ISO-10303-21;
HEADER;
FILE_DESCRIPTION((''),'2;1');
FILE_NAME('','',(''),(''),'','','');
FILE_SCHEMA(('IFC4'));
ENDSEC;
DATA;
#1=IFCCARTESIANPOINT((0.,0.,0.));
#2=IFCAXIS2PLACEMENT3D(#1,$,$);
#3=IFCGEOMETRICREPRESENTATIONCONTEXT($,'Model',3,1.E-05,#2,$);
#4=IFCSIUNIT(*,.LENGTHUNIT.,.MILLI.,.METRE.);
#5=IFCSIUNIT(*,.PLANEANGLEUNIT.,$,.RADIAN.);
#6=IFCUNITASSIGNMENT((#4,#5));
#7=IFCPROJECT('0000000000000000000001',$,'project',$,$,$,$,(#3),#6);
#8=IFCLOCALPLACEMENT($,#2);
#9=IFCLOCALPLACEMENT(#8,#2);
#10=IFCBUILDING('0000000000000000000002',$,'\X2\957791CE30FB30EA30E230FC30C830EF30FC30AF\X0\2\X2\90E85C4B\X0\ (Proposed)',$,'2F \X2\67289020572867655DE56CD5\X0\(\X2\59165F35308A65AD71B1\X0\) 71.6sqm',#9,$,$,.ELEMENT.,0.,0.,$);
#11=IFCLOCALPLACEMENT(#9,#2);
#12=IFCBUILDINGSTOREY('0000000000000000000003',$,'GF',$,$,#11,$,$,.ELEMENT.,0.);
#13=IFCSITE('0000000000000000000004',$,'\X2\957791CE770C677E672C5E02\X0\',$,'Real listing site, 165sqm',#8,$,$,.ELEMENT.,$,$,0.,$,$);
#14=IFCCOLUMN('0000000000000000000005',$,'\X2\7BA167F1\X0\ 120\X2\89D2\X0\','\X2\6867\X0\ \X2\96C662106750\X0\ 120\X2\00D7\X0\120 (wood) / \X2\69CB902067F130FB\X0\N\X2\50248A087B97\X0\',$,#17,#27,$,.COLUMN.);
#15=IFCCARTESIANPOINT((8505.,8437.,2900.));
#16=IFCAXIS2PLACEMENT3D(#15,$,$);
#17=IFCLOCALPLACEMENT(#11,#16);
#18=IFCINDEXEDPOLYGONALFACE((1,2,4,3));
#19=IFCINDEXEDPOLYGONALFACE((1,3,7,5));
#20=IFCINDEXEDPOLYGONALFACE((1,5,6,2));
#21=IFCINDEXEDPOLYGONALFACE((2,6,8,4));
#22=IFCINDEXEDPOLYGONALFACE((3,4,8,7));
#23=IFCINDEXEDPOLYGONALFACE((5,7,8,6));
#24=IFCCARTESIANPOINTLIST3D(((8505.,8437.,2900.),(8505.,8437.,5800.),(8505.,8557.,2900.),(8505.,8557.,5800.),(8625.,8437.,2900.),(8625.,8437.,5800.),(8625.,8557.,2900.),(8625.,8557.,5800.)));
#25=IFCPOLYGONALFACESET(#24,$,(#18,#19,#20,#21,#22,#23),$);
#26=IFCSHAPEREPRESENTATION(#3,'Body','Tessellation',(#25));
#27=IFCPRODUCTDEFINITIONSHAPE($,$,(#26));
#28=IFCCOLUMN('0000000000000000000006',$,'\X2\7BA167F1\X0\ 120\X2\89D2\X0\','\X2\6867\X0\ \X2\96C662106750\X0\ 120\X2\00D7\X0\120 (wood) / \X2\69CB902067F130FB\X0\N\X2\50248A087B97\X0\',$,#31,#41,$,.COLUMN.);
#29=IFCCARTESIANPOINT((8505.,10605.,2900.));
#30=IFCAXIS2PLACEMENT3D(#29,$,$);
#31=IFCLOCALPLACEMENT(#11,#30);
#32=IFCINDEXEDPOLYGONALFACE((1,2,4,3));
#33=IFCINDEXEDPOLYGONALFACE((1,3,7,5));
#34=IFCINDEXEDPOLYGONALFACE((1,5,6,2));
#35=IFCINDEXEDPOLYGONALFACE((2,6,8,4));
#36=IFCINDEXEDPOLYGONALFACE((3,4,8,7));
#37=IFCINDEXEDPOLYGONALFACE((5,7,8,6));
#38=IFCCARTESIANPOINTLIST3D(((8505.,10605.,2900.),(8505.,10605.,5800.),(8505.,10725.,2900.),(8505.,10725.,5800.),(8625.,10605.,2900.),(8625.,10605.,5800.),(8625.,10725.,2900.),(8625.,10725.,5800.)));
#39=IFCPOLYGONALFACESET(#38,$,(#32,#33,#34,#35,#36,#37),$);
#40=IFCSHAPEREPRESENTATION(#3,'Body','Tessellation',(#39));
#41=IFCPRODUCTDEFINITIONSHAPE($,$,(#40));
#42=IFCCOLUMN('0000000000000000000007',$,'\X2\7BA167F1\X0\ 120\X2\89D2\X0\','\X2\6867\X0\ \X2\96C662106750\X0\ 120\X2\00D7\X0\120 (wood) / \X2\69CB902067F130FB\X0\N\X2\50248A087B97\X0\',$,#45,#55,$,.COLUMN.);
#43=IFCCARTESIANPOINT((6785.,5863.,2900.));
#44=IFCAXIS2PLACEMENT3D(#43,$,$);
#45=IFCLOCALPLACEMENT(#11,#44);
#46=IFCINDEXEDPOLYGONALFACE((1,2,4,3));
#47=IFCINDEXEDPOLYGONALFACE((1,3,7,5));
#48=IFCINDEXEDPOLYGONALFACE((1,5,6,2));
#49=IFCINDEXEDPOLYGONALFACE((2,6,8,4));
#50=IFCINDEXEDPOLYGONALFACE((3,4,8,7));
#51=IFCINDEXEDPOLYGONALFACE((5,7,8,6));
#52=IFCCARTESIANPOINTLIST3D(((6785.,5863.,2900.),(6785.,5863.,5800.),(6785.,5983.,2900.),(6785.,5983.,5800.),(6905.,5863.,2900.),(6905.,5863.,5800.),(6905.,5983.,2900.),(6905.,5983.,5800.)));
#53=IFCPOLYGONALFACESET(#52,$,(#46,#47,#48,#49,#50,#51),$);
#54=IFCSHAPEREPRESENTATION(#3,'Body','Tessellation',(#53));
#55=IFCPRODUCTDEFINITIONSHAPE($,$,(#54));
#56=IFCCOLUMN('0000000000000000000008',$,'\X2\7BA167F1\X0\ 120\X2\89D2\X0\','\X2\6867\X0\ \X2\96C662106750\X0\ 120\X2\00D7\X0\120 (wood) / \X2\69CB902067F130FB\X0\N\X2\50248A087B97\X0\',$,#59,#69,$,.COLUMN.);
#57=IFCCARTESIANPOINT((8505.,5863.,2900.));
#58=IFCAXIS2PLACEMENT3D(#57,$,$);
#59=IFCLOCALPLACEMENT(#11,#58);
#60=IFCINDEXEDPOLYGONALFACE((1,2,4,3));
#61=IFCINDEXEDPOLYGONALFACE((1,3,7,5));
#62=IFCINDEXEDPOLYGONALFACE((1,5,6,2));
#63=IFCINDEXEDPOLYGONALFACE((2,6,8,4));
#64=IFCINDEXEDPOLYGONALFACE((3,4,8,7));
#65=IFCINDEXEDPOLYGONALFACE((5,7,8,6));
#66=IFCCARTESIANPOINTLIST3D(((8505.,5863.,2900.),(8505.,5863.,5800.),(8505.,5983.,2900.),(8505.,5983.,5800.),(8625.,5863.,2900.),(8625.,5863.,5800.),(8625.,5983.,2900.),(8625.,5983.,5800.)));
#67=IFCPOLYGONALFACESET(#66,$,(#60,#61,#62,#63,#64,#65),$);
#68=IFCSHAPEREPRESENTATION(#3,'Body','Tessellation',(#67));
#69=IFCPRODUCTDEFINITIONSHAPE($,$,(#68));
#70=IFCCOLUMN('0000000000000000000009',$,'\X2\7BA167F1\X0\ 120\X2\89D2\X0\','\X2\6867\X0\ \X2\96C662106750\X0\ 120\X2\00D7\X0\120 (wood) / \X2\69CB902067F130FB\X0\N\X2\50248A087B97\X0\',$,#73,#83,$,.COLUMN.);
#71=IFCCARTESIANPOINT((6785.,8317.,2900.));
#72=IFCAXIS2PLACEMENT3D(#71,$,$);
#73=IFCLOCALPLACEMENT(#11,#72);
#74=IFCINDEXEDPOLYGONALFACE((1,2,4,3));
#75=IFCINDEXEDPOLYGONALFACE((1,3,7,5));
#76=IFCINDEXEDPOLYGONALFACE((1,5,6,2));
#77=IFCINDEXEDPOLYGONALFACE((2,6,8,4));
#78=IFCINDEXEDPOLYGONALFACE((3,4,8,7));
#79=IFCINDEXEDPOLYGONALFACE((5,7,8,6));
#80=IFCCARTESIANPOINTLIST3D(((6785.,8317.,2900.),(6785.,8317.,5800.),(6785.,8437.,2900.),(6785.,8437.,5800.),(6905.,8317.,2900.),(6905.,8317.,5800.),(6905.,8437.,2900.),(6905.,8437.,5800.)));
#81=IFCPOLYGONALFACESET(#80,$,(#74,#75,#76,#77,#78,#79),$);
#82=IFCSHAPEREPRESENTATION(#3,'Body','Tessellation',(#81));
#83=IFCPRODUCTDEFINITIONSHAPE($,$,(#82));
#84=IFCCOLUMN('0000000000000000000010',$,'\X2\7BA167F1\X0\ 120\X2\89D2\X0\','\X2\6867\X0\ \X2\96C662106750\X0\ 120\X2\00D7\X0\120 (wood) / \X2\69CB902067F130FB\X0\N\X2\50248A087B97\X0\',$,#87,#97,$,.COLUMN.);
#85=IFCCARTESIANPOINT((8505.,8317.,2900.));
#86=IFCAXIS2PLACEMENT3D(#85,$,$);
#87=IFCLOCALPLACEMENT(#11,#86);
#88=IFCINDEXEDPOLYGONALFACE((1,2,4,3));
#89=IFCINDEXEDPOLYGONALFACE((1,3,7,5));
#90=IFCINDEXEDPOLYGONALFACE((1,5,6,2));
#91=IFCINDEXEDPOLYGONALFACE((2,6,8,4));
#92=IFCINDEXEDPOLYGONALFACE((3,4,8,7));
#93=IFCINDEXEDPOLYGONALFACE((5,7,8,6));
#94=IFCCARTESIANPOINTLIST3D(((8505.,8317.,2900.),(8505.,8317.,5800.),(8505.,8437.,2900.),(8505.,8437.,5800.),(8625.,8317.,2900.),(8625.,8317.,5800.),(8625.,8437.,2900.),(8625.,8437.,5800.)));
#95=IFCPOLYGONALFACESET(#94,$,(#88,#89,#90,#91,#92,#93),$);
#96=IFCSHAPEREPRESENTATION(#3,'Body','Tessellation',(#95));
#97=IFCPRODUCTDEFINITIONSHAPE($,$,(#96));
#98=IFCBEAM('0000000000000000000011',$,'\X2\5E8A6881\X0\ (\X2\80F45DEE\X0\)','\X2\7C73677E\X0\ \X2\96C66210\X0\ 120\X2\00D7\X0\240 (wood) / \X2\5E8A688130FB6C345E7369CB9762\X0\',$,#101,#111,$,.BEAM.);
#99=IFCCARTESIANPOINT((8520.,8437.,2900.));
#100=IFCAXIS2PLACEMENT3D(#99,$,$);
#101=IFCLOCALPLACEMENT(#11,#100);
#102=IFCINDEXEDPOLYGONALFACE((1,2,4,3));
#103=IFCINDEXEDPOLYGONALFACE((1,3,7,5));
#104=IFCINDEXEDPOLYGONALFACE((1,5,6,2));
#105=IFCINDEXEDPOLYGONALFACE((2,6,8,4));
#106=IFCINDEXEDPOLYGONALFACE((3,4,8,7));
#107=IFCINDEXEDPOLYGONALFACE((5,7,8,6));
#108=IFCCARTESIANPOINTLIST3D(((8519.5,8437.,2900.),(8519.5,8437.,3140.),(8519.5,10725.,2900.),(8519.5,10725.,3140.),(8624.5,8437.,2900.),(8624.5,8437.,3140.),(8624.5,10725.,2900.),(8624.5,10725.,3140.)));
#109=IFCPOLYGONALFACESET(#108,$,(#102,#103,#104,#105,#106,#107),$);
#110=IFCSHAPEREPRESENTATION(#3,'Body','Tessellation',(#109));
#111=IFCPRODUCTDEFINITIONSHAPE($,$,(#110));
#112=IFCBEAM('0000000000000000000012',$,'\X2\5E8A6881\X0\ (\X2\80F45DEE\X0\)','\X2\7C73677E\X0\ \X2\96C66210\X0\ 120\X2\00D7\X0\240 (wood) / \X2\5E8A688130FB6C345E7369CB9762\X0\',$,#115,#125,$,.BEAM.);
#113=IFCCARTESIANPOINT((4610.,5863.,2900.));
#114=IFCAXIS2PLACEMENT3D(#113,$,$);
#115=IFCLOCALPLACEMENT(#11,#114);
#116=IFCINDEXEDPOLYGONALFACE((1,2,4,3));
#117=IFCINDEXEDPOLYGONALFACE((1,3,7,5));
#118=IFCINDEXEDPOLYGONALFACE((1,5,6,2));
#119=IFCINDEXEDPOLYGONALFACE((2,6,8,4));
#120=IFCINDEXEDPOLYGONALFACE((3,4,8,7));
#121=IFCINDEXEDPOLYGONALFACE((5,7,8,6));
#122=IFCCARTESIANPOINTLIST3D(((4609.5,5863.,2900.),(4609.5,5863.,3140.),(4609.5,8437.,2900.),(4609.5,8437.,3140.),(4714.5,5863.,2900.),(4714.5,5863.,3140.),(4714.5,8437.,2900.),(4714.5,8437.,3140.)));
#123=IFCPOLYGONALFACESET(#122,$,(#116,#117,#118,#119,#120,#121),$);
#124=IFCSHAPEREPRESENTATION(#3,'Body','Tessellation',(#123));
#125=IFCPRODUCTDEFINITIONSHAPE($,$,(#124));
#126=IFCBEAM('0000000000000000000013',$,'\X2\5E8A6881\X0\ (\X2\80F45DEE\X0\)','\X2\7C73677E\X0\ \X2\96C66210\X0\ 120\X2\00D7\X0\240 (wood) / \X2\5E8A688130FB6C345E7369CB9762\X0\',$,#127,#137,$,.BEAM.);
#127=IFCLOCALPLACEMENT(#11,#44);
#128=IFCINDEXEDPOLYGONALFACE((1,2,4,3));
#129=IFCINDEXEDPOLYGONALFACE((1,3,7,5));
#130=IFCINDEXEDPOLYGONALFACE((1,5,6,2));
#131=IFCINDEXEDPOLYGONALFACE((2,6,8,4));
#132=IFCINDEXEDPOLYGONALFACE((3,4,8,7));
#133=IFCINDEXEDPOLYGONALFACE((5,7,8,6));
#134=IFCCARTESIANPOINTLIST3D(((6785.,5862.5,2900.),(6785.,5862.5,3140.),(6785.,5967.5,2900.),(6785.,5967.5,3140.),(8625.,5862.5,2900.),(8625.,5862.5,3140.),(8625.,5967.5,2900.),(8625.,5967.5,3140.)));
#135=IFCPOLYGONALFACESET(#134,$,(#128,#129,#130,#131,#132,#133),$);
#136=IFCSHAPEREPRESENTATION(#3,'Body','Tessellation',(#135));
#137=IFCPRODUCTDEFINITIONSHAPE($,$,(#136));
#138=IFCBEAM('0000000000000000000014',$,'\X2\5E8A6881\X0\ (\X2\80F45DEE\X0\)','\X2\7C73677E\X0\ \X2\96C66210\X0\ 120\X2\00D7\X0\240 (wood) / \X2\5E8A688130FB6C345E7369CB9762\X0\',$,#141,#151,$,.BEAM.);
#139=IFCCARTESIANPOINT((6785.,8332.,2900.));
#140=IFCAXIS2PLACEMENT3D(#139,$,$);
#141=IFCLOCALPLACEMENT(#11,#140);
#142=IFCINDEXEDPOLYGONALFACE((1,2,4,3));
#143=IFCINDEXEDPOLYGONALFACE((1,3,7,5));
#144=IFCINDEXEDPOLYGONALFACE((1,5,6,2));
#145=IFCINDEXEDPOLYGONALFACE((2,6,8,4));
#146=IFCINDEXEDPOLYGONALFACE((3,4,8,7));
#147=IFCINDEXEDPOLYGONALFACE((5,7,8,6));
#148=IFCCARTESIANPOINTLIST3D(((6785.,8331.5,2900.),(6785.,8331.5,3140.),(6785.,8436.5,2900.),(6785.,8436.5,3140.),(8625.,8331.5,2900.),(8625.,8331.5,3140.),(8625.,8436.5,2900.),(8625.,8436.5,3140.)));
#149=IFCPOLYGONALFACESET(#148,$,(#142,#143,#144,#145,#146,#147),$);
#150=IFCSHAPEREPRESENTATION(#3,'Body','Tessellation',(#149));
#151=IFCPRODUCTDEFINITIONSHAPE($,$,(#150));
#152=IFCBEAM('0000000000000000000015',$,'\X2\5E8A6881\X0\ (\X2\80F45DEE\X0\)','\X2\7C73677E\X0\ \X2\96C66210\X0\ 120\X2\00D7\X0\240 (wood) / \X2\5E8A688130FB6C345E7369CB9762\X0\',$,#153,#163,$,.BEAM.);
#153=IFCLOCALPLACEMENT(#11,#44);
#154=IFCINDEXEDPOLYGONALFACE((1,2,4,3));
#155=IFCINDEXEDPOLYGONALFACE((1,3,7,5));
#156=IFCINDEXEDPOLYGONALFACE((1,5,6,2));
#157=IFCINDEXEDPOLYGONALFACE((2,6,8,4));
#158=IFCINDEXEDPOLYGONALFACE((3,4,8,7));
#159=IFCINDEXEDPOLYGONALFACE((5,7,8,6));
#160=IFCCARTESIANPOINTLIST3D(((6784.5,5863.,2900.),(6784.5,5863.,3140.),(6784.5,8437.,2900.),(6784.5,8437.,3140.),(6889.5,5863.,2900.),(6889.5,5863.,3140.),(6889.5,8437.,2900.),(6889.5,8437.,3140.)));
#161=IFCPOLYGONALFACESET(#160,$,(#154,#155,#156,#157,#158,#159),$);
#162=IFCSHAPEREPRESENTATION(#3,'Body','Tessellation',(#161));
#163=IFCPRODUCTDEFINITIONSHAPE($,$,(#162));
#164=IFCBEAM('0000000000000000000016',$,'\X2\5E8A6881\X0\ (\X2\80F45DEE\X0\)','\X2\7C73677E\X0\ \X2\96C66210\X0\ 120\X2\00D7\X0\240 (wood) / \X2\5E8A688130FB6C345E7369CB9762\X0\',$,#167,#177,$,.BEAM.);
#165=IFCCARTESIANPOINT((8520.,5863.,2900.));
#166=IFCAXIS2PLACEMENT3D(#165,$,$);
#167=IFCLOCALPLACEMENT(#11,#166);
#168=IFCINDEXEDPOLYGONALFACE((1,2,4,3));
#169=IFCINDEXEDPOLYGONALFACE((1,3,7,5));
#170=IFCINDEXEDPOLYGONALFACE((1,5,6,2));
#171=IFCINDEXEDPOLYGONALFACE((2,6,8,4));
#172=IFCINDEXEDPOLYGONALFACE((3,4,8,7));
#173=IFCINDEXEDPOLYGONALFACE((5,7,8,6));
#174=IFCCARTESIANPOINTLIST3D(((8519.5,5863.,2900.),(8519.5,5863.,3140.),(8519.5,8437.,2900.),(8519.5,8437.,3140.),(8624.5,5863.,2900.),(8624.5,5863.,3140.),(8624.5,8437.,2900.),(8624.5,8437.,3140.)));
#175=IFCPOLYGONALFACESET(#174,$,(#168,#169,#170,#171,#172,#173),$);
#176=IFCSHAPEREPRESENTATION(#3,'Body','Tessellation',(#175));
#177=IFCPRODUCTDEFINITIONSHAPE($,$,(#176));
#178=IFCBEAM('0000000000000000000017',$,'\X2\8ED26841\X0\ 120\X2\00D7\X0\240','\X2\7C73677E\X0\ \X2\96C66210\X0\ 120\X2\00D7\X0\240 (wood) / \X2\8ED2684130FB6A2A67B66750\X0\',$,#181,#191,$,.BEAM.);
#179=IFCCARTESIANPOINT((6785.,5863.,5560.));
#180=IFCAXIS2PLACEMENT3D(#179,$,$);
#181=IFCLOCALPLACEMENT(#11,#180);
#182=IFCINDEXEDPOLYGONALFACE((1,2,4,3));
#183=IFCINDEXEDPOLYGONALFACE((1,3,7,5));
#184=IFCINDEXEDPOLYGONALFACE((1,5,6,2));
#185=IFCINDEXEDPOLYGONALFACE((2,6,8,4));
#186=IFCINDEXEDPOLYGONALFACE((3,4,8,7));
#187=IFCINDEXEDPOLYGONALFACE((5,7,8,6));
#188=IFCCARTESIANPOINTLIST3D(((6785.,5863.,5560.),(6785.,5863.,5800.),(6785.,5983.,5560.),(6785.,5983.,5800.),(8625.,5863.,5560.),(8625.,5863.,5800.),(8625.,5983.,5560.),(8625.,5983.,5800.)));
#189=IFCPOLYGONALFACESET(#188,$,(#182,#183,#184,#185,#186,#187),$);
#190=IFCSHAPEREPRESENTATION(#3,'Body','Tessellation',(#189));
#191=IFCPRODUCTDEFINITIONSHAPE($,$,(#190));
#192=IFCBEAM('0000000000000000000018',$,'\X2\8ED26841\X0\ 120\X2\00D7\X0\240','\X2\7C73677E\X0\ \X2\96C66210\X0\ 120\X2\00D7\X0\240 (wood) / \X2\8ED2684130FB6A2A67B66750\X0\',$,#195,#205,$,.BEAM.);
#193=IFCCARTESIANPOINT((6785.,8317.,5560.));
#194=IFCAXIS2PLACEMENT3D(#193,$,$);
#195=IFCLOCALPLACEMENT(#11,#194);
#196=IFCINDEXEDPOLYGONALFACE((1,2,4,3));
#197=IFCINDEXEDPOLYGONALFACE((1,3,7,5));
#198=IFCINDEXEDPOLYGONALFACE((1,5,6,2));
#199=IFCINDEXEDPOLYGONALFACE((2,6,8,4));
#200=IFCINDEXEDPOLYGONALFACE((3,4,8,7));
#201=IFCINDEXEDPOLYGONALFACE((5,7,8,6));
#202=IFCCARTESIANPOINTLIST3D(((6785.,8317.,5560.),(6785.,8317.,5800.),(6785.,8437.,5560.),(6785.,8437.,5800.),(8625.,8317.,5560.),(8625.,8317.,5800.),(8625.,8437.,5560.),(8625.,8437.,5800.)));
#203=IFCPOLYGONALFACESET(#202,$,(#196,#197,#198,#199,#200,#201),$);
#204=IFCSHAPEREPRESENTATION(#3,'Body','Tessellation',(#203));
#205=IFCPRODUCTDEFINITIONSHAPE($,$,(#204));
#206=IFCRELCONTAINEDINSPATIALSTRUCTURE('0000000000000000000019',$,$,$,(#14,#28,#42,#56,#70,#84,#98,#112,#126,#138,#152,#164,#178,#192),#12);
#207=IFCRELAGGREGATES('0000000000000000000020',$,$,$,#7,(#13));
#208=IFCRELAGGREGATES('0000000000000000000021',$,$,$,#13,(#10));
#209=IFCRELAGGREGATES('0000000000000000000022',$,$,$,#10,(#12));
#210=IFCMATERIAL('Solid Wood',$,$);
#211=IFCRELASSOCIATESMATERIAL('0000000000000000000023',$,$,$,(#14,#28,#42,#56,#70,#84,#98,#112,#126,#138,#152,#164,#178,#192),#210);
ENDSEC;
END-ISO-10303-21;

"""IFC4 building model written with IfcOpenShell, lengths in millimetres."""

from ifc_helpers import new_model, si_unit, frame, frame_2d, origin, place, context, project, spatial, rectangle, extrude, material, element, save


model = new_model("IFC4")

# Units and contexts
model_context = context("Model", 3, precision=1e-05, world=origin())
ifc_project = project(units=[si_unit("LENGTHUNIT", "METRE", prefix="MILLI"), si_unit("PLANEANGLEUNIT", "RADIAN")], contexts=[model_context])

# Site, building, storey
site_placement = place(None, origin())
site = spatial("IfcSite", under=ifc_project, at=site_placement, Name="長野県松本市", ObjectType="Real listing site, 165sqm", CompositionType="ELEMENT", RefElevation=0.0)
building_placement = place(site_placement, origin())
building = spatial("IfcBuilding", under=site, at=building_placement, Name="長野・リモートワーク2部屋 (Proposed)", ObjectType="2F 木造在来工法(外張り断熱) 71.6sqm", CompositionType="ELEMENT", ElevationOfRefHeight=0.0, ElevationOfTerrain=0.0)
storey_placement = place(building_placement, origin())
storey = spatial("IfcBuildingStorey", under=building, at=storey_placement, Name="GF", CompositionType="ELEMENT", Elevation=0.0)

# Columns
ifc_material_1 = material(Name="Solid Wood")
column_1_placement = place(storey_placement, frame((8505.0, 8437.0, 2900.0)))
element("IfcColumn", 1, at=column_1_placement, inside=storey, material=ifc_material_1, Name="管柱 120角", Description="桧 集成材 120×120 (wood) / 構造柱・N値計算", PredefinedType="COLUMN", context=model_context, shape_type="SweptSolid", body=[
    extrude(rectangle(XDim=120.0, YDim=120.0, at=frame_2d((60.0, 60.0))), frame((8505.0, 8437.0, 2900.0)), (0.0, 0.0, 1.0), 2900.0),
])
column_2_placement = place(storey_placement, frame((8505.0, 10605.0, 2900.0)))
element("IfcColumn", 2, at=column_2_placement, inside=storey, material=ifc_material_1, Name="管柱 120角", Description="桧 集成材 120×120 (wood) / 構造柱・N値計算", PredefinedType="COLUMN", context=model_context, shape_type="SweptSolid", body=[
    extrude(rectangle(XDim=120.0, YDim=120.0, at=frame_2d((60.0, 60.0))), frame((8505.0, 10605.0, 2900.0)), (0.0, 0.0, 1.0), 2900.0),
])
column_3_placement = place(storey_placement, frame((6785.0, 5863.0, 2900.0)))
element("IfcColumn", 3, at=column_3_placement, inside=storey, material=ifc_material_1, Name="管柱 120角", Description="桧 集成材 120×120 (wood) / 構造柱・N値計算", PredefinedType="COLUMN", context=model_context, shape_type="SweptSolid", body=[
    extrude(rectangle(XDim=120.0, YDim=120.0, at=frame_2d((60.0, 60.0))), frame((6785.0, 5863.0, 2900.0)), (0.0, 0.0, 1.0), 2900.0),
])
column_4_placement = place(storey_placement, frame((8505.0, 5863.0, 2900.0)))
element("IfcColumn", 4, at=column_4_placement, inside=storey, material=ifc_material_1, Name="管柱 120角", Description="桧 集成材 120×120 (wood) / 構造柱・N値計算", PredefinedType="COLUMN", context=model_context, shape_type="SweptSolid", body=[
    extrude(rectangle(XDim=120.0, YDim=120.0, at=frame_2d((60.0, 60.0))), frame((8505.0, 5863.0, 2900.0)), (0.0, 0.0, 1.0), 2900.0),
])
column_5_placement = place(storey_placement, frame((6785.0, 8317.0, 2900.0)))
element("IfcColumn", 5, at=column_5_placement, inside=storey, material=ifc_material_1, Name="管柱 120角", Description="桧 集成材 120×120 (wood) / 構造柱・N値計算", PredefinedType="COLUMN", context=model_context, shape_type="SweptSolid", body=[
    extrude(rectangle(XDim=120.0, YDim=120.0, at=frame_2d((60.0, 60.0))), frame((6785.0, 8317.0, 2900.0)), (0.0, 0.0, 1.0), 2900.0),
])
column_6_placement = place(storey_placement, frame((8505.0, 8317.0, 2900.0)))
element("IfcColumn", 6, at=column_6_placement, inside=storey, material=ifc_material_1, Name="管柱 120角", Description="桧 集成材 120×120 (wood) / 構造柱・N値計算", PredefinedType="COLUMN", context=model_context, shape_type="SweptSolid", body=[
    extrude(rectangle(XDim=120.0, YDim=120.0, at=frame_2d((60.0, 60.0))), frame((8505.0, 8317.0, 2900.0)), (0.0, 0.0, 1.0), 2900.0),
])

# Beams
beam_1_placement = place(storey_placement, frame((8520.0, 8437.0, 2900.0)))
element("IfcBeam", 7, at=beam_1_placement, inside=storey, material=ifc_material_1, Name="床梁 (胴差)", Description="米松 集成 120×240 (wood) / 床梁・水平構面", PredefinedType="BEAM", context=model_context, shape_type="SweptSolid", body=[
    extrude(rectangle(XDim=105.0, YDim=2288.0, at=frame_2d((52.0, 1144.0))), frame((8520.0, 8437.0, 2900.0)), (0.0, 0.0, 1.0), 240.0),
])
beam_2_placement = place(storey_placement, frame((4610.0, 5863.0, 2900.0)))
element("IfcBeam", 8, at=beam_2_placement, inside=storey, material=ifc_material_1, Name="床梁 (胴差)", Description="米松 集成 120×240 (wood) / 床梁・水平構面", PredefinedType="BEAM", context=model_context, shape_type="SweptSolid", body=[
    extrude(rectangle(XDim=105.0, YDim=2574.0, at=frame_2d((52.0, 1287.0))), frame((4610.0, 5863.0, 2900.0)), (0.0, 0.0, 1.0), 240.0),
])
beam_3_placement = place(storey_placement, frame((6785.0, 5863.0, 2900.0)))
element("IfcBeam", 9, at=beam_3_placement, inside=storey, material=ifc_material_1, Name="床梁 (胴差)", Description="米松 集成 120×240 (wood) / 床梁・水平構面", PredefinedType="BEAM", context=model_context, shape_type="SweptSolid", body=[
    extrude(rectangle(XDim=1840.0, YDim=105.0, at=frame_2d((920.0, 52.0))), frame((6785.0, 5863.0, 2900.0)), (0.0, 0.0, 1.0), 240.0),
])
beam_4_placement = place(storey_placement, frame((6785.0, 8332.0, 2900.0)))
element("IfcBeam", 10, at=beam_4_placement, inside=storey, material=ifc_material_1, Name="床梁 (胴差)", Description="米松 集成 120×240 (wood) / 床梁・水平構面", PredefinedType="BEAM", context=model_context, shape_type="SweptSolid", body=[
    extrude(rectangle(XDim=1840.0, YDim=105.0, at=frame_2d((920.0, 52.0))), frame((6785.0, 8332.0, 2900.0)), (0.0, 0.0, 1.0), 240.0),
])
beam_5_placement = place(storey_placement, frame((6785.0, 5863.0, 2900.0)))
element("IfcBeam", 11, at=beam_5_placement, inside=storey, material=ifc_material_1, Name="床梁 (胴差)", Description="米松 集成 120×240 (wood) / 床梁・水平構面", PredefinedType="BEAM", context=model_context, shape_type="SweptSolid", body=[
    extrude(rectangle(XDim=105.0, YDim=2574.0, at=frame_2d((52.0, 1287.0))), frame((6785.0, 5863.0, 2900.0)), (0.0, 0.0, 1.0), 240.0),
])
beam_6_placement = place(storey_placement, frame((8520.0, 5863.0, 2900.0)))
element("IfcBeam", 12, at=beam_6_placement, inside=storey, material=ifc_material_1, Name="床梁 (胴差)", Description="米松 集成 120×240 (wood) / 床梁・水平構面", PredefinedType="BEAM", context=model_context, shape_type="SweptSolid", body=[
    extrude(rectangle(XDim=105.0, YDim=2574.0, at=frame_2d((52.0, 1287.0))), frame((8520.0, 5863.0, 2900.0)), (0.0, 0.0, 1.0), 240.0),
])
beam_7_placement = place(storey_placement, frame((6785.0, 5863.0, 5560.0)))
element("IfcBeam", 13, at=beam_7_placement, inside=storey, material=ifc_material_1, Name="軒桁 120×240", Description="米松 集成 120×240 (wood) / 軒桁・横架材", PredefinedType="BEAM", context=model_context, shape_type="SweptSolid", body=[
    extrude(rectangle(XDim=1840.0, YDim=120.0, at=frame_2d((920.0, 60.0))), frame((6785.0, 5863.0, 5560.0)), (0.0, 0.0, 1.0), 240.0),
])
beam_8_placement = place(storey_placement, frame((6785.0, 8317.0, 5560.0)))
element("IfcBeam", 14, at=beam_8_placement, inside=storey, material=ifc_material_1, Name="軒桁 120×240", Description="米松 集成 120×240 (wood) / 軒桁・横架材", PredefinedType="BEAM", context=model_context, shape_type="SweptSolid", body=[
    extrude(rectangle(XDim=1840.0, YDim=120.0, at=frame_2d((920.0, 60.0))), frame((6785.0, 8317.0, 5560.0)), (0.0, 0.0, 1.0), 240.0),
])

save(model, "model.ifc")
